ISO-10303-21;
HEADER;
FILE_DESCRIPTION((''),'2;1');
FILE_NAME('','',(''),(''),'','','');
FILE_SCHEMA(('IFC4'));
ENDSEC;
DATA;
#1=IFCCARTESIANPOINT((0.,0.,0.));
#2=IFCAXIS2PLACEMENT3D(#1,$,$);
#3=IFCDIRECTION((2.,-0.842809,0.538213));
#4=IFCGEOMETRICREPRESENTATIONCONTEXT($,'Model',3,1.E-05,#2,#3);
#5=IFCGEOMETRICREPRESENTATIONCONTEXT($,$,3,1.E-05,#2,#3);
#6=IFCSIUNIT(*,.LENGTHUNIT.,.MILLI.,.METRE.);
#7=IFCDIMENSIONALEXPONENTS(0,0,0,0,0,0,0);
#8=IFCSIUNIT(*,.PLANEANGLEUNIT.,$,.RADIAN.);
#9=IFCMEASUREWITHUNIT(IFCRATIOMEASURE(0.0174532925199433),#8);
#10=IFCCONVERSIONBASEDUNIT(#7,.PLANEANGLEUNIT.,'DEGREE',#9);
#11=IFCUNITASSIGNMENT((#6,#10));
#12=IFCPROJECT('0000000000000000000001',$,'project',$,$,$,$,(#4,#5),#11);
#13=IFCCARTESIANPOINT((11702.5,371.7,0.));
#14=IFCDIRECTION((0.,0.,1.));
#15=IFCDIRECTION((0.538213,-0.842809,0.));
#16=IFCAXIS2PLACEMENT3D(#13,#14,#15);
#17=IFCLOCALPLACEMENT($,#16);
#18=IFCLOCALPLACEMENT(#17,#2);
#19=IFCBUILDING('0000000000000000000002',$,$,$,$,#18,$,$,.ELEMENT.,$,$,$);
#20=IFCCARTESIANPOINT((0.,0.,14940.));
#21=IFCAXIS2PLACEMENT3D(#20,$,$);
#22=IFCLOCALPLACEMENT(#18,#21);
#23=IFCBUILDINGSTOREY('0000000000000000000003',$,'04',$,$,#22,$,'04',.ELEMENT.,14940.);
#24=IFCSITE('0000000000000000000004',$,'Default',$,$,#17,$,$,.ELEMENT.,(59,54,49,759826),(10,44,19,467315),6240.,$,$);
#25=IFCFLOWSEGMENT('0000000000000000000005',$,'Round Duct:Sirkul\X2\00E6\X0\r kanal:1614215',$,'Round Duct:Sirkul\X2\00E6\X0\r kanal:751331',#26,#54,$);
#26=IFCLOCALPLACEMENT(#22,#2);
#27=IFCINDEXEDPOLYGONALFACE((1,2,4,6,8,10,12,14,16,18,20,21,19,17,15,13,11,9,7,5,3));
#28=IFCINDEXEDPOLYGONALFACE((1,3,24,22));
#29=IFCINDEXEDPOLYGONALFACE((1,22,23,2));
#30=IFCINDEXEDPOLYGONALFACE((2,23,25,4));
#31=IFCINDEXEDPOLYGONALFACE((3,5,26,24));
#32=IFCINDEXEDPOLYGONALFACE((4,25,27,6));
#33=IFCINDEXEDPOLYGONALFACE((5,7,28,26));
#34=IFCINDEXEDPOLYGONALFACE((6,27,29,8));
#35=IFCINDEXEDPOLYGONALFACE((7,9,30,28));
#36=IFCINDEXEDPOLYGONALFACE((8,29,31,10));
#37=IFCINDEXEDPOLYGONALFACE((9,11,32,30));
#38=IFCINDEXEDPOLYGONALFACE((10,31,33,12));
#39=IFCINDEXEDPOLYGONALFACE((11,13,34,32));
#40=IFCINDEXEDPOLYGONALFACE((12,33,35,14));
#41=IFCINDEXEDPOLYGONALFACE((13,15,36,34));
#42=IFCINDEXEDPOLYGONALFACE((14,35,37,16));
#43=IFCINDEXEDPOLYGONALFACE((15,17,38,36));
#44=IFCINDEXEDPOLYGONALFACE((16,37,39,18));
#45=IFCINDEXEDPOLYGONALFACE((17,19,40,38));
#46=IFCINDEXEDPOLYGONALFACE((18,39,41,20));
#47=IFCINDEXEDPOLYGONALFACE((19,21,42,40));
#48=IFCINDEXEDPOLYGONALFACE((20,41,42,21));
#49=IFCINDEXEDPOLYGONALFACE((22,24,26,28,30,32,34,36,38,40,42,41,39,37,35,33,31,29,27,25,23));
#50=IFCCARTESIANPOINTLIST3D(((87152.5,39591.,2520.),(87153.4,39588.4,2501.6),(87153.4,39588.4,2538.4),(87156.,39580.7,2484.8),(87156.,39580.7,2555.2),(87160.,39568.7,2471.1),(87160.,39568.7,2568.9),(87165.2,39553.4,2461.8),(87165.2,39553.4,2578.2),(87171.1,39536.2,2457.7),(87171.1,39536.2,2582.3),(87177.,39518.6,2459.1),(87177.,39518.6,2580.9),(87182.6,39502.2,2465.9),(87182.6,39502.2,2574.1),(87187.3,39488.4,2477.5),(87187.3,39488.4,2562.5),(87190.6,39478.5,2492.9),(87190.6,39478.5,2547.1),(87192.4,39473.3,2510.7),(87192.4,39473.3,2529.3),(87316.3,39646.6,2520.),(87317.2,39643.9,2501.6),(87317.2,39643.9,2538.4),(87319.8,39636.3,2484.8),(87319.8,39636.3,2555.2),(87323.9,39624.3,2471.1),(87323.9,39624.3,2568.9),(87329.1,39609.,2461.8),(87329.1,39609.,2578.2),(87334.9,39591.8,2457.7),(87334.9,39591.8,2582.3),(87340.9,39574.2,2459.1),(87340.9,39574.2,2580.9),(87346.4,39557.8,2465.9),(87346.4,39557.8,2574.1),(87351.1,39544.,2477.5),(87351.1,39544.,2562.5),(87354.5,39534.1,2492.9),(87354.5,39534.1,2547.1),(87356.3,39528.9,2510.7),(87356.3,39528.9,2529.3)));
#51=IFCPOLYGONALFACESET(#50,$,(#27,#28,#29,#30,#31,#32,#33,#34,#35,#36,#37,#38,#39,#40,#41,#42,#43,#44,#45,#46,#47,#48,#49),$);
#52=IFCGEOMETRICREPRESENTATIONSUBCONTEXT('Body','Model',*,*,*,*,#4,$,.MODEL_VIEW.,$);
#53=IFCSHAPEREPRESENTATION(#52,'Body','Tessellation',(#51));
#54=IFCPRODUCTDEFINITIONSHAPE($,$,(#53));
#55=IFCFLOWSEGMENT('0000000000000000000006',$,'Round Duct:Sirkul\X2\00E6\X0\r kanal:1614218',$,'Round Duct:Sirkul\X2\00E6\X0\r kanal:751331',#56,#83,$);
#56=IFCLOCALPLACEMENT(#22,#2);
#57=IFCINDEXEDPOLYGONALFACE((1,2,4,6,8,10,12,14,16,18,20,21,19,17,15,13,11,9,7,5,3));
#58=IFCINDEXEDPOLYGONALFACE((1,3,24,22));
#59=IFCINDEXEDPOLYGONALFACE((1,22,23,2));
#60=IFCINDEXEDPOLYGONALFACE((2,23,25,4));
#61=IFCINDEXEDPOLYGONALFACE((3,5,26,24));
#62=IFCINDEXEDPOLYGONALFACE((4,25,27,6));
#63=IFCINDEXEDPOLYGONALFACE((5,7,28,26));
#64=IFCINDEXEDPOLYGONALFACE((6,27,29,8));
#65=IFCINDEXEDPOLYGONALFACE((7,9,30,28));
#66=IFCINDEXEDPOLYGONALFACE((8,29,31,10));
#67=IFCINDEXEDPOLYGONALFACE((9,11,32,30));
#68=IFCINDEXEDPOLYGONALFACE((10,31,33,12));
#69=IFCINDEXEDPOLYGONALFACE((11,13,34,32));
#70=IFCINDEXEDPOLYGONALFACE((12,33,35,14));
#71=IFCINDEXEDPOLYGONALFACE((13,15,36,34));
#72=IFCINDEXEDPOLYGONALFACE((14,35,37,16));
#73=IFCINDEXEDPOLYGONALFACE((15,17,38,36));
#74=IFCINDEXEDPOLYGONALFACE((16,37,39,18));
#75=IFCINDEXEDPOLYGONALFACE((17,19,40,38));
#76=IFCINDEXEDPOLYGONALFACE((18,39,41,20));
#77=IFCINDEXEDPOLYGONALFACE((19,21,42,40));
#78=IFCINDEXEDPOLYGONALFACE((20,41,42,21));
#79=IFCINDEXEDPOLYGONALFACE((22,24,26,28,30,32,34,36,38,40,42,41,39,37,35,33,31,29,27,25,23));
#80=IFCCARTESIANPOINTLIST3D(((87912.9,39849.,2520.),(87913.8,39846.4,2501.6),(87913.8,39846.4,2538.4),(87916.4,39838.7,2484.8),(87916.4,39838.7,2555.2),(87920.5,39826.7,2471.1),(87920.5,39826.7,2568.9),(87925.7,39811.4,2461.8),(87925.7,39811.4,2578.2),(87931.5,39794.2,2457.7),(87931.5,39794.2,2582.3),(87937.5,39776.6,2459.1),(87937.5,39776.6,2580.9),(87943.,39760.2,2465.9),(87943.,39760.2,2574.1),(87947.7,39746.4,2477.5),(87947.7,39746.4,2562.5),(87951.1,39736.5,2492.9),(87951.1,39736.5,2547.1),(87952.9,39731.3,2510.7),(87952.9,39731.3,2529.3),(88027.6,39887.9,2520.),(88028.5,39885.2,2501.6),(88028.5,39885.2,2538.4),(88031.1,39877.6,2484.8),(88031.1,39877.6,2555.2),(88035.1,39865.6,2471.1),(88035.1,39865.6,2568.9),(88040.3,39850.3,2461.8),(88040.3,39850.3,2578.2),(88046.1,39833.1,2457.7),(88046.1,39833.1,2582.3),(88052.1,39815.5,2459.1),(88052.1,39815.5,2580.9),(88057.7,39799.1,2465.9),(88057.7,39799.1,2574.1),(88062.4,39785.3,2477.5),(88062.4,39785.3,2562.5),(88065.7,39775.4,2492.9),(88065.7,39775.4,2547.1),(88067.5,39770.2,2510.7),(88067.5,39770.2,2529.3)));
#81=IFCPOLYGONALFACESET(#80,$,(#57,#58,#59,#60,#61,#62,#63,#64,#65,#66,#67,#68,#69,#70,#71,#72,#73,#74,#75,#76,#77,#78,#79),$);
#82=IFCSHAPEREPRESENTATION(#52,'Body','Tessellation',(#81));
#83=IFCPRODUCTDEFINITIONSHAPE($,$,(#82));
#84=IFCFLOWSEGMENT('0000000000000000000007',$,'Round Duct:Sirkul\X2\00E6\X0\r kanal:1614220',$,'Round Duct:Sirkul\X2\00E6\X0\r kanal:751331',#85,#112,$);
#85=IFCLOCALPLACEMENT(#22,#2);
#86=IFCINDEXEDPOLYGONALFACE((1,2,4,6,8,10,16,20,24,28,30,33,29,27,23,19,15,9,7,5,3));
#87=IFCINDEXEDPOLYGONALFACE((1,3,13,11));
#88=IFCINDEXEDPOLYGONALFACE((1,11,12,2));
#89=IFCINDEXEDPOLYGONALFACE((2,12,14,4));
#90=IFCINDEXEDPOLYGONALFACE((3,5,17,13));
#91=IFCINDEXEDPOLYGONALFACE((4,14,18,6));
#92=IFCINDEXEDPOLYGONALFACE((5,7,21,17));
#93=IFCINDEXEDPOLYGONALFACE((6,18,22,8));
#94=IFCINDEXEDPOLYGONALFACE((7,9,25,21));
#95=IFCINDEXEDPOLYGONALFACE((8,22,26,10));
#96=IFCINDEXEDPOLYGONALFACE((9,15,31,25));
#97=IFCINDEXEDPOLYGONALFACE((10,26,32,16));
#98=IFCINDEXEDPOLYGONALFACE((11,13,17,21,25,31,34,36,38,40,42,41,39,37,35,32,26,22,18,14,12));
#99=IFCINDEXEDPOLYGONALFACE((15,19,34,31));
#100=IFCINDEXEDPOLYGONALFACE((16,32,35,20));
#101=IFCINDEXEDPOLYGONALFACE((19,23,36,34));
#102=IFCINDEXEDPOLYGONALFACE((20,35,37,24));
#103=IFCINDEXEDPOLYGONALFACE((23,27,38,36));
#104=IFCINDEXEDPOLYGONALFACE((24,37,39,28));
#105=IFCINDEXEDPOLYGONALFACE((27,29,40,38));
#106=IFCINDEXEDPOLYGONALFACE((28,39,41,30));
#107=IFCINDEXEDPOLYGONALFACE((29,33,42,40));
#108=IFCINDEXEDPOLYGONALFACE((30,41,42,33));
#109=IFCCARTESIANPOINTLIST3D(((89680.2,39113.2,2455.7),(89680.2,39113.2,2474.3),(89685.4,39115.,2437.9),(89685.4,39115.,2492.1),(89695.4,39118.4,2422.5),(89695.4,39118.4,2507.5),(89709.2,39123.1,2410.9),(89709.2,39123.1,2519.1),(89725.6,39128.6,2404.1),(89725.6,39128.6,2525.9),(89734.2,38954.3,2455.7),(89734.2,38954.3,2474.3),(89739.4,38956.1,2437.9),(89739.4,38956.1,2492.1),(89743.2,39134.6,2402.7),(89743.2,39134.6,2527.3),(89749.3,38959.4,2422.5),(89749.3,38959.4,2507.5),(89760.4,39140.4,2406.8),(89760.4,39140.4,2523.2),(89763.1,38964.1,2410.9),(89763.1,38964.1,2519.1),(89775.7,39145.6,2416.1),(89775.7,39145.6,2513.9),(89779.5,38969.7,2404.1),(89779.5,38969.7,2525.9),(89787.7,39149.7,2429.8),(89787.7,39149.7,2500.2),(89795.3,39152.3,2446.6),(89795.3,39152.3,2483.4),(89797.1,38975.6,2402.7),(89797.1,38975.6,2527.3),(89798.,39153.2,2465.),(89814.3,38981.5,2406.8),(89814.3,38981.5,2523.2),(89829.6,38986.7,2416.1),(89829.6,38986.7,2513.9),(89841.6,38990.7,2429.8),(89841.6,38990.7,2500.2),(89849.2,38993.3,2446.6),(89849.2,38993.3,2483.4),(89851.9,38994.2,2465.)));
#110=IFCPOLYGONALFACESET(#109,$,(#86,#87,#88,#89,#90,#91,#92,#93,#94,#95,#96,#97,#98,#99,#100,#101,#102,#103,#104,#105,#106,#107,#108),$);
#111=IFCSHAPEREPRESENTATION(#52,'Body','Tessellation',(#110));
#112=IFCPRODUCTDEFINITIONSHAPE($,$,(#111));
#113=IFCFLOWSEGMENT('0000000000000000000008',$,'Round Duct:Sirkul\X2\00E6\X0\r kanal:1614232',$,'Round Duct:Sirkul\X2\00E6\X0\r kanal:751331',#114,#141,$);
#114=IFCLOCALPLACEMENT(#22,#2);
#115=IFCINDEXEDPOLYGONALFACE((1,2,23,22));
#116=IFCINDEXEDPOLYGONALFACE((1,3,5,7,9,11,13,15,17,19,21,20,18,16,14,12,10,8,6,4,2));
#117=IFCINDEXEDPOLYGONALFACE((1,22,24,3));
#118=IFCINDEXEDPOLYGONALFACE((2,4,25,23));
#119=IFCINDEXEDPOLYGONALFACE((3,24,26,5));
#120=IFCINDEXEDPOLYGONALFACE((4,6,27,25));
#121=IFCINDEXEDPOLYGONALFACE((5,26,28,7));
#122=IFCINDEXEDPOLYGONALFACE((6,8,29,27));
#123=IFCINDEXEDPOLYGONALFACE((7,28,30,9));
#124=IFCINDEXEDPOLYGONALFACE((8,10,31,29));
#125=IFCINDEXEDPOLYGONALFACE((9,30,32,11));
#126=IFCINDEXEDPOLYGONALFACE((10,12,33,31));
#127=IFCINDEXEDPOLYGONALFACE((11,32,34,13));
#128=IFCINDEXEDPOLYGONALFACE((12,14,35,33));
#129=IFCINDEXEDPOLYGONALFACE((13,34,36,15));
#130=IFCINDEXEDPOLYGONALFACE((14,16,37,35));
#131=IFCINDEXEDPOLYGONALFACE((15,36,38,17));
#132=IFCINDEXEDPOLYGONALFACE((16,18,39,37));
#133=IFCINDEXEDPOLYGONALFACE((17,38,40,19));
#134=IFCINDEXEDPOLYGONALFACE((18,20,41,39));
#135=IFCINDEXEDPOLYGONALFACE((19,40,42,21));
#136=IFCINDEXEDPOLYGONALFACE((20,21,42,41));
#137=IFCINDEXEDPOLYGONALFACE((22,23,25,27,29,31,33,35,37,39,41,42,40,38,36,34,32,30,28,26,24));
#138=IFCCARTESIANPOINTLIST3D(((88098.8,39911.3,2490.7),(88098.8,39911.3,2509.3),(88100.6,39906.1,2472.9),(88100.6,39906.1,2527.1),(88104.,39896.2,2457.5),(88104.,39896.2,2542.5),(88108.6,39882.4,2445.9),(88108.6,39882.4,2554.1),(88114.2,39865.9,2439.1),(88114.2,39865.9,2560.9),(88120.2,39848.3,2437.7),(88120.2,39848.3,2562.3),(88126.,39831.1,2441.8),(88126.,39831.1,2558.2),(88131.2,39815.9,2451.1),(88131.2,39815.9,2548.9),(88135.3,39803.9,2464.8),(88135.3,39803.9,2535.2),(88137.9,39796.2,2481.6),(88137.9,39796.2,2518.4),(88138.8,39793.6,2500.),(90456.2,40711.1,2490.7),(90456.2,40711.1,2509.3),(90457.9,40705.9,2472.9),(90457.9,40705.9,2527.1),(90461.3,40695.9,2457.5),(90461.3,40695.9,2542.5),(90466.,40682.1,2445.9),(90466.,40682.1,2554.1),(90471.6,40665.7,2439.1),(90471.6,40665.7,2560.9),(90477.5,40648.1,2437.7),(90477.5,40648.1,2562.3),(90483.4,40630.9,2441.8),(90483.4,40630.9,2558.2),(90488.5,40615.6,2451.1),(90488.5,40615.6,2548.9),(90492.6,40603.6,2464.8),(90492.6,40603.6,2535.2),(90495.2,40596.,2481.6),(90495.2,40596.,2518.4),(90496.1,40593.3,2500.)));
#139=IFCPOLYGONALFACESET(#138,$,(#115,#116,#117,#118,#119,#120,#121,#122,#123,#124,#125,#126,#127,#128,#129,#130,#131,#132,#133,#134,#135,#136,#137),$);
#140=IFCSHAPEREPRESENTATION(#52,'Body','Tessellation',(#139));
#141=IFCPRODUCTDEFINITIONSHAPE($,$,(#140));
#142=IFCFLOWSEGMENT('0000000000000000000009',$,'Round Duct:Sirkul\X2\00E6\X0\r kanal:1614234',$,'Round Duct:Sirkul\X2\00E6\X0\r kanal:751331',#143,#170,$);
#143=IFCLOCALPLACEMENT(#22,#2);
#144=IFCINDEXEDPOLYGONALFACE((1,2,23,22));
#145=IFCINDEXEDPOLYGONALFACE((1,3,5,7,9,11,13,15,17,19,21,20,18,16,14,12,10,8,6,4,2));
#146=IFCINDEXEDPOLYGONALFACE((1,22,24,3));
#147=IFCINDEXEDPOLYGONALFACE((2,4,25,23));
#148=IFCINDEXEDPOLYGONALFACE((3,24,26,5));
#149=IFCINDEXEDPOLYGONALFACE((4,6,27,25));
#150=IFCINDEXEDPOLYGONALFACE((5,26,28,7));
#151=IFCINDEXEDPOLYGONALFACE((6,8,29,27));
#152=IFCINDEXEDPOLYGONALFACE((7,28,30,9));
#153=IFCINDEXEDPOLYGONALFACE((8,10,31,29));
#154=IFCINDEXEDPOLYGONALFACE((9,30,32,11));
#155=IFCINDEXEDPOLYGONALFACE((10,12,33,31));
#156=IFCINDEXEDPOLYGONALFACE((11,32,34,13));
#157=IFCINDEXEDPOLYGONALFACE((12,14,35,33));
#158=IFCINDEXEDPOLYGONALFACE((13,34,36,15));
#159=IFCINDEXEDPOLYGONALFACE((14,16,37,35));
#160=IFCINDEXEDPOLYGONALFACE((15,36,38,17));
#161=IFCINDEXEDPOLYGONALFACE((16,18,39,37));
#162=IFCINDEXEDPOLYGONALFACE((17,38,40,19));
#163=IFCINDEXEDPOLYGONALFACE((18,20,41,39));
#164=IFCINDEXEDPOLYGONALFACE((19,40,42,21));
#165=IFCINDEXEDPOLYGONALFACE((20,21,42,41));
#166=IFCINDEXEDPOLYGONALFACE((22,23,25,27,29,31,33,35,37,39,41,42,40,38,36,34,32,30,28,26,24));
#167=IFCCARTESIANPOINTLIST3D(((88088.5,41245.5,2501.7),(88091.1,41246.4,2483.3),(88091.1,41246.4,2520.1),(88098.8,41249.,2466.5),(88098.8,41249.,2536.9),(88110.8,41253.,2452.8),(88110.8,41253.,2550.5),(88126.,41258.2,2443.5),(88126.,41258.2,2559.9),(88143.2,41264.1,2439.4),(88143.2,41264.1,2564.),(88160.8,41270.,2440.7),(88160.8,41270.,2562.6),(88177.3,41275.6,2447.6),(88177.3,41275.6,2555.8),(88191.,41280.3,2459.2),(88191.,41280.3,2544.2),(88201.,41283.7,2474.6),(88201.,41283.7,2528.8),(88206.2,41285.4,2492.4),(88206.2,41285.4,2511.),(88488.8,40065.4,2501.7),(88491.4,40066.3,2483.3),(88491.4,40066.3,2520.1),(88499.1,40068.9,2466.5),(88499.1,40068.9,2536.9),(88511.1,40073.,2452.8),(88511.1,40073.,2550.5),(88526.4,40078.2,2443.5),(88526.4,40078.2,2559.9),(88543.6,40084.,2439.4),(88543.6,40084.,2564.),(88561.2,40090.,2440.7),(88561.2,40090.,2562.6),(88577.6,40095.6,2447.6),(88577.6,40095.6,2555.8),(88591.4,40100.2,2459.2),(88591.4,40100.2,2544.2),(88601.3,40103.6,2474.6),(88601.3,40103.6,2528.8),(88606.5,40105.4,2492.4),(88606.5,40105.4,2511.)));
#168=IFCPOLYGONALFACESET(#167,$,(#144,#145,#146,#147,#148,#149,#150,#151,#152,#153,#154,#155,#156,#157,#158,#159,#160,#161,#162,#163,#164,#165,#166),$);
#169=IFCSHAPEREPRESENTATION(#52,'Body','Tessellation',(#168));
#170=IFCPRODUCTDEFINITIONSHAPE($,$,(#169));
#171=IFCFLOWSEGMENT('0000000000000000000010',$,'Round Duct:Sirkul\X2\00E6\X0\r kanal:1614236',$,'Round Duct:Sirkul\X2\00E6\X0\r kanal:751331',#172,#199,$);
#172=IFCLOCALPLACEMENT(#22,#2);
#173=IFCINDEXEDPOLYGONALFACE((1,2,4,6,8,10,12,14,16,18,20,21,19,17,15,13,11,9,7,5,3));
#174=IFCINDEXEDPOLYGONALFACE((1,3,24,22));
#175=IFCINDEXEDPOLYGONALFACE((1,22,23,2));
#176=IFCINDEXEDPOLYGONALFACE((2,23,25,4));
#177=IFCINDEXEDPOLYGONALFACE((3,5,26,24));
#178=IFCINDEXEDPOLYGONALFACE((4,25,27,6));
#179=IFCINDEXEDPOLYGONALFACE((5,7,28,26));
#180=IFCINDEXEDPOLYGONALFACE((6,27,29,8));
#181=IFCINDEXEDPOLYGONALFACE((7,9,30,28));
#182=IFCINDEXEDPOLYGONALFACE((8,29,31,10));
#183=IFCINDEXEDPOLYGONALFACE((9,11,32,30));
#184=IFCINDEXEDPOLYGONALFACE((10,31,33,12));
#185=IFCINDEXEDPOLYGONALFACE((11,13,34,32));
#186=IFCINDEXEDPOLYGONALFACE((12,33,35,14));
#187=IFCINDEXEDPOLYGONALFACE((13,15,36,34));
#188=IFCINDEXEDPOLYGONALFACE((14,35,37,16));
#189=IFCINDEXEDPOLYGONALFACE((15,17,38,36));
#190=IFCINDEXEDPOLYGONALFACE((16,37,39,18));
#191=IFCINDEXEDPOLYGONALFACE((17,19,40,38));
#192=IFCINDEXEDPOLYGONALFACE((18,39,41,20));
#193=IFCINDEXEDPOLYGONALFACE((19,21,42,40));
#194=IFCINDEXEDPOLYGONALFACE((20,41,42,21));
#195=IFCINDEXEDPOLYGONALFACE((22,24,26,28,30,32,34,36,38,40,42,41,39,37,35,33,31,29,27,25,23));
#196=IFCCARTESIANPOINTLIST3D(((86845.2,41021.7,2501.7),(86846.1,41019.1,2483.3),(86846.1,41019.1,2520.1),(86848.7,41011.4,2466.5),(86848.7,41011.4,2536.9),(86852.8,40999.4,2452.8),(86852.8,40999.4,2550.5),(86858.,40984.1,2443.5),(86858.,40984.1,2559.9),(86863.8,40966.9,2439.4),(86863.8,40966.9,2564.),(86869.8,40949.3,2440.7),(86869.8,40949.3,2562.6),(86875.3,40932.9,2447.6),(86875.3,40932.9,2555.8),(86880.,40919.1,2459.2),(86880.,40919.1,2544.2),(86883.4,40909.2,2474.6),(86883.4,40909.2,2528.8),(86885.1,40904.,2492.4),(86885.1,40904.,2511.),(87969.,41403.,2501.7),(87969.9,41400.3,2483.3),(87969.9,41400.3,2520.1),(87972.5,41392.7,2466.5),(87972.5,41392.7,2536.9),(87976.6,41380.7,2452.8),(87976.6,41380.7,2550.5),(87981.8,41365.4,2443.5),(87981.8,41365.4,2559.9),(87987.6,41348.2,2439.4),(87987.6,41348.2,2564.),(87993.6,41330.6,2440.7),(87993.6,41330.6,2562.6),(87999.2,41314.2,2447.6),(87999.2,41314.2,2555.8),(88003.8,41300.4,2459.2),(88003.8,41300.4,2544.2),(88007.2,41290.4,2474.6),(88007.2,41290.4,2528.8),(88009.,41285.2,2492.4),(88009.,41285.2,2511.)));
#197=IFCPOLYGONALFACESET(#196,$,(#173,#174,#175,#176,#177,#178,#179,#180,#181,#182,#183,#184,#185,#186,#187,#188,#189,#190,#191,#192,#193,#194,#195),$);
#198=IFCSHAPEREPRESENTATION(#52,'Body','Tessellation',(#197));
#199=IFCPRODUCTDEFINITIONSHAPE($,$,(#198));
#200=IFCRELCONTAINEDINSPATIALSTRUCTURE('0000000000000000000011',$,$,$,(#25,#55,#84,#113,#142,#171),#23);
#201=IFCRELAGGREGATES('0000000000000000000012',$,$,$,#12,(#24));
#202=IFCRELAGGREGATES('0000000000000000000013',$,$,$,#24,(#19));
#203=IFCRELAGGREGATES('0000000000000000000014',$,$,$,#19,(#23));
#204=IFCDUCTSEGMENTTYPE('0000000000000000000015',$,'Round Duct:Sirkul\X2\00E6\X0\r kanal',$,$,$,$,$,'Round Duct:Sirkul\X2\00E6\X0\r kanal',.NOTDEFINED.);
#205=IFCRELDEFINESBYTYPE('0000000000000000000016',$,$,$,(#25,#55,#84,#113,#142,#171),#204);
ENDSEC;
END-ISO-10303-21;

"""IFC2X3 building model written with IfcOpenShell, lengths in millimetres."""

from ifc_helpers import new_model, entity, si_unit, converted_unit, direction, frame, origin, origin_2d_with_axis, place, context, subcontext, project, spatial, circle, extrude, type_object, element, save


model = new_model("IFC2X3")

# Units and contexts
model_context = context("Model", 3, precision=1e-05, world=origin(), true_north=direction((2.0, -0.842809, 0.538213)))
context_of_model = context(None, 3, precision=1e-05, world=origin(), true_north=direction((2.0, -0.842809, 0.538213)))
body_context = subcontext(model_context, "Body", "Model", "MODEL_VIEW")
ifc_project = project(units=[si_unit("LENGTHUNIT", "METRE", prefix="MILLI"), converted_unit("PLANEANGLEUNIT", "DEGREE", entity("IfcRatioMeasure", 0.0174532925199433), si_unit("PLANEANGLEUNIT", "RADIAN"), dimensions=[0, 0, 0, 0, 0, 0, 0])], contexts=[model_context, context_of_model])

# Site, building, storey
site_placement = place(None, frame((11702.5, 371.7, 0.0), z_axis=(0.0, 0.0, 1.0), x_axis=(0.538213, -0.842809, 0.0)))
site = spatial("IfcSite", under=ifc_project, at=site_placement, Name="Default", CompositionType="ELEMENT", RefLatitude=(59, 54, 49, 759826), RefLongitude=(10, 44, 19, 467315), RefElevation=6240.0)
building_placement = place(site_placement, origin())
building = spatial("IfcBuilding", under=site, at=building_placement, CompositionType="ELEMENT")
storey_placement = place(building_placement, frame((0.0, 0.0, 14940.0)))
storey = spatial("IfcBuildingStorey", under=building, at=storey_placement, Name="04", LongName="04", CompositionType="ELEMENT", Elevation=14940.0)

# Flow segments
duct_segment_type = type_object("IfcDuctSegmentType", Name="Round Duct:Sirkulær kanal", ElementType="Round Duct:Sirkulær kanal", PredefinedType="NOTDEFINED")
flow_segment_1_placement = place(storey_placement, origin())
element("IfcFlowSegment", 1, at=flow_segment_1_placement, inside=storey, type_object=duct_segment_type, Name="Round Duct:Sirkulær kanal:1614215", ObjectType="Round Duct:Sirkulær kanal:751331", context=body_context, shape_type="SweptSolid", body=[
    extrude(circle(Radius=62.5, at=origin_2d_with_axis()), frame((87172.6, 39531.8, 2520.0), z_axis=(0.946986, 0.321274, 0.0), x_axis=(-0.321274, 0.946986, 0.0)), (0.0, 0.0, 1.0), 173.0),
])
flow_segment_2_placement = place(storey_placement, origin())
element("IfcFlowSegment", 2, at=flow_segment_2_placement, inside=storey, type_object=duct_segment_type, Name="Round Duct:Sirkulær kanal:1614218", ObjectType="Round Duct:Sirkulær kanal:751331", context=body_context, shape_type="SweptSolid", body=[
    extrude(circle(Radius=62.5, at=origin_2d_with_axis()), frame((87933.0, 39789.8, 2520.0), z_axis=(0.946986, 0.321274, 0.0), x_axis=(-0.321274, 0.946986, 0.0)), (0.0, 0.0, 1.0), 121.1),
])
flow_segment_3_placement = place(storey_placement, origin())
element("IfcFlowSegment", 3, at=flow_segment_3_placement, inside=storey, type_object=duct_segment_type, Name="Round Duct:Sirkulær kanal:1614220", ObjectType="Round Duct:Sirkulær kanal:751331", context=body_context, shape_type="SweptSolid", body=[
    extrude(circle(Radius=62.5, at=origin_2d_with_axis()), frame((89792.7, 38974.1, 2465.0), z_axis=(-0.321246, 0.946996, 0.0), x_axis=(0.946996, 0.321246, 0.0)), (0.0, 0.0, 1.0), 167.8),
])
flow_segment_4_placement = place(storey_placement, origin())
element("IfcFlowSegment", 4, at=flow_segment_4_placement, inside=storey, type_object=duct_segment_type, Name="Round Duct:Sirkulær kanal:1614232", ObjectType="Round Duct:Sirkulær kanal:751331", context=body_context, shape_type="SweptSolid", body=[
    extrude(circle(Radius=62.5, at=origin_2d_with_axis()), frame((88118.7, 39852.8, 2500.0), z_axis=(0.946986, 0.321274, 0.0), x_axis=(0.321274, -0.946986, 0.0)), (0.0, 0.0, 1.0), 2489.3),
])
flow_segment_5_placement = place(storey_placement, origin())
element("IfcFlowSegment", 5, at=flow_segment_5_placement, inside=storey, type_object=duct_segment_type, Name="Round Duct:Sirkulær kanal:1614234", ObjectType="Round Duct:Sirkulær kanal:751331", context=body_context, shape_type="SweptSolid", body=[
    extrude(circle(Radius=62.5, at=origin_2d_with_axis()), frame((88548.0, 40085.5, 2501.7), z_axis=(-0.321274, 0.946986, 0.0), x_axis=(-0.946986, -0.321274, 0.0)), (0.0, 0.0, 1.0), 1246.1),
])
flow_segment_6_placement = place(storey_placement, origin())
element("IfcFlowSegment", 6, at=flow_segment_6_placement, inside=storey, type_object=duct_segment_type, Name="Round Duct:Sirkulær kanal:1614236", ObjectType="Round Duct:Sirkulær kanal:751331", context=body_context, shape_type="SweptSolid", body=[
    extrude(circle(Radius=62.5, at=origin_2d_with_axis()), frame((86865.3, 40962.5, 2501.7), z_axis=(0.946986, 0.321274, 0.0), x_axis=(-0.321274, 0.946986, 0.0)), (0.0, 0.0, 1.0), 1186.7),
])

save(model, "model.ifc")
